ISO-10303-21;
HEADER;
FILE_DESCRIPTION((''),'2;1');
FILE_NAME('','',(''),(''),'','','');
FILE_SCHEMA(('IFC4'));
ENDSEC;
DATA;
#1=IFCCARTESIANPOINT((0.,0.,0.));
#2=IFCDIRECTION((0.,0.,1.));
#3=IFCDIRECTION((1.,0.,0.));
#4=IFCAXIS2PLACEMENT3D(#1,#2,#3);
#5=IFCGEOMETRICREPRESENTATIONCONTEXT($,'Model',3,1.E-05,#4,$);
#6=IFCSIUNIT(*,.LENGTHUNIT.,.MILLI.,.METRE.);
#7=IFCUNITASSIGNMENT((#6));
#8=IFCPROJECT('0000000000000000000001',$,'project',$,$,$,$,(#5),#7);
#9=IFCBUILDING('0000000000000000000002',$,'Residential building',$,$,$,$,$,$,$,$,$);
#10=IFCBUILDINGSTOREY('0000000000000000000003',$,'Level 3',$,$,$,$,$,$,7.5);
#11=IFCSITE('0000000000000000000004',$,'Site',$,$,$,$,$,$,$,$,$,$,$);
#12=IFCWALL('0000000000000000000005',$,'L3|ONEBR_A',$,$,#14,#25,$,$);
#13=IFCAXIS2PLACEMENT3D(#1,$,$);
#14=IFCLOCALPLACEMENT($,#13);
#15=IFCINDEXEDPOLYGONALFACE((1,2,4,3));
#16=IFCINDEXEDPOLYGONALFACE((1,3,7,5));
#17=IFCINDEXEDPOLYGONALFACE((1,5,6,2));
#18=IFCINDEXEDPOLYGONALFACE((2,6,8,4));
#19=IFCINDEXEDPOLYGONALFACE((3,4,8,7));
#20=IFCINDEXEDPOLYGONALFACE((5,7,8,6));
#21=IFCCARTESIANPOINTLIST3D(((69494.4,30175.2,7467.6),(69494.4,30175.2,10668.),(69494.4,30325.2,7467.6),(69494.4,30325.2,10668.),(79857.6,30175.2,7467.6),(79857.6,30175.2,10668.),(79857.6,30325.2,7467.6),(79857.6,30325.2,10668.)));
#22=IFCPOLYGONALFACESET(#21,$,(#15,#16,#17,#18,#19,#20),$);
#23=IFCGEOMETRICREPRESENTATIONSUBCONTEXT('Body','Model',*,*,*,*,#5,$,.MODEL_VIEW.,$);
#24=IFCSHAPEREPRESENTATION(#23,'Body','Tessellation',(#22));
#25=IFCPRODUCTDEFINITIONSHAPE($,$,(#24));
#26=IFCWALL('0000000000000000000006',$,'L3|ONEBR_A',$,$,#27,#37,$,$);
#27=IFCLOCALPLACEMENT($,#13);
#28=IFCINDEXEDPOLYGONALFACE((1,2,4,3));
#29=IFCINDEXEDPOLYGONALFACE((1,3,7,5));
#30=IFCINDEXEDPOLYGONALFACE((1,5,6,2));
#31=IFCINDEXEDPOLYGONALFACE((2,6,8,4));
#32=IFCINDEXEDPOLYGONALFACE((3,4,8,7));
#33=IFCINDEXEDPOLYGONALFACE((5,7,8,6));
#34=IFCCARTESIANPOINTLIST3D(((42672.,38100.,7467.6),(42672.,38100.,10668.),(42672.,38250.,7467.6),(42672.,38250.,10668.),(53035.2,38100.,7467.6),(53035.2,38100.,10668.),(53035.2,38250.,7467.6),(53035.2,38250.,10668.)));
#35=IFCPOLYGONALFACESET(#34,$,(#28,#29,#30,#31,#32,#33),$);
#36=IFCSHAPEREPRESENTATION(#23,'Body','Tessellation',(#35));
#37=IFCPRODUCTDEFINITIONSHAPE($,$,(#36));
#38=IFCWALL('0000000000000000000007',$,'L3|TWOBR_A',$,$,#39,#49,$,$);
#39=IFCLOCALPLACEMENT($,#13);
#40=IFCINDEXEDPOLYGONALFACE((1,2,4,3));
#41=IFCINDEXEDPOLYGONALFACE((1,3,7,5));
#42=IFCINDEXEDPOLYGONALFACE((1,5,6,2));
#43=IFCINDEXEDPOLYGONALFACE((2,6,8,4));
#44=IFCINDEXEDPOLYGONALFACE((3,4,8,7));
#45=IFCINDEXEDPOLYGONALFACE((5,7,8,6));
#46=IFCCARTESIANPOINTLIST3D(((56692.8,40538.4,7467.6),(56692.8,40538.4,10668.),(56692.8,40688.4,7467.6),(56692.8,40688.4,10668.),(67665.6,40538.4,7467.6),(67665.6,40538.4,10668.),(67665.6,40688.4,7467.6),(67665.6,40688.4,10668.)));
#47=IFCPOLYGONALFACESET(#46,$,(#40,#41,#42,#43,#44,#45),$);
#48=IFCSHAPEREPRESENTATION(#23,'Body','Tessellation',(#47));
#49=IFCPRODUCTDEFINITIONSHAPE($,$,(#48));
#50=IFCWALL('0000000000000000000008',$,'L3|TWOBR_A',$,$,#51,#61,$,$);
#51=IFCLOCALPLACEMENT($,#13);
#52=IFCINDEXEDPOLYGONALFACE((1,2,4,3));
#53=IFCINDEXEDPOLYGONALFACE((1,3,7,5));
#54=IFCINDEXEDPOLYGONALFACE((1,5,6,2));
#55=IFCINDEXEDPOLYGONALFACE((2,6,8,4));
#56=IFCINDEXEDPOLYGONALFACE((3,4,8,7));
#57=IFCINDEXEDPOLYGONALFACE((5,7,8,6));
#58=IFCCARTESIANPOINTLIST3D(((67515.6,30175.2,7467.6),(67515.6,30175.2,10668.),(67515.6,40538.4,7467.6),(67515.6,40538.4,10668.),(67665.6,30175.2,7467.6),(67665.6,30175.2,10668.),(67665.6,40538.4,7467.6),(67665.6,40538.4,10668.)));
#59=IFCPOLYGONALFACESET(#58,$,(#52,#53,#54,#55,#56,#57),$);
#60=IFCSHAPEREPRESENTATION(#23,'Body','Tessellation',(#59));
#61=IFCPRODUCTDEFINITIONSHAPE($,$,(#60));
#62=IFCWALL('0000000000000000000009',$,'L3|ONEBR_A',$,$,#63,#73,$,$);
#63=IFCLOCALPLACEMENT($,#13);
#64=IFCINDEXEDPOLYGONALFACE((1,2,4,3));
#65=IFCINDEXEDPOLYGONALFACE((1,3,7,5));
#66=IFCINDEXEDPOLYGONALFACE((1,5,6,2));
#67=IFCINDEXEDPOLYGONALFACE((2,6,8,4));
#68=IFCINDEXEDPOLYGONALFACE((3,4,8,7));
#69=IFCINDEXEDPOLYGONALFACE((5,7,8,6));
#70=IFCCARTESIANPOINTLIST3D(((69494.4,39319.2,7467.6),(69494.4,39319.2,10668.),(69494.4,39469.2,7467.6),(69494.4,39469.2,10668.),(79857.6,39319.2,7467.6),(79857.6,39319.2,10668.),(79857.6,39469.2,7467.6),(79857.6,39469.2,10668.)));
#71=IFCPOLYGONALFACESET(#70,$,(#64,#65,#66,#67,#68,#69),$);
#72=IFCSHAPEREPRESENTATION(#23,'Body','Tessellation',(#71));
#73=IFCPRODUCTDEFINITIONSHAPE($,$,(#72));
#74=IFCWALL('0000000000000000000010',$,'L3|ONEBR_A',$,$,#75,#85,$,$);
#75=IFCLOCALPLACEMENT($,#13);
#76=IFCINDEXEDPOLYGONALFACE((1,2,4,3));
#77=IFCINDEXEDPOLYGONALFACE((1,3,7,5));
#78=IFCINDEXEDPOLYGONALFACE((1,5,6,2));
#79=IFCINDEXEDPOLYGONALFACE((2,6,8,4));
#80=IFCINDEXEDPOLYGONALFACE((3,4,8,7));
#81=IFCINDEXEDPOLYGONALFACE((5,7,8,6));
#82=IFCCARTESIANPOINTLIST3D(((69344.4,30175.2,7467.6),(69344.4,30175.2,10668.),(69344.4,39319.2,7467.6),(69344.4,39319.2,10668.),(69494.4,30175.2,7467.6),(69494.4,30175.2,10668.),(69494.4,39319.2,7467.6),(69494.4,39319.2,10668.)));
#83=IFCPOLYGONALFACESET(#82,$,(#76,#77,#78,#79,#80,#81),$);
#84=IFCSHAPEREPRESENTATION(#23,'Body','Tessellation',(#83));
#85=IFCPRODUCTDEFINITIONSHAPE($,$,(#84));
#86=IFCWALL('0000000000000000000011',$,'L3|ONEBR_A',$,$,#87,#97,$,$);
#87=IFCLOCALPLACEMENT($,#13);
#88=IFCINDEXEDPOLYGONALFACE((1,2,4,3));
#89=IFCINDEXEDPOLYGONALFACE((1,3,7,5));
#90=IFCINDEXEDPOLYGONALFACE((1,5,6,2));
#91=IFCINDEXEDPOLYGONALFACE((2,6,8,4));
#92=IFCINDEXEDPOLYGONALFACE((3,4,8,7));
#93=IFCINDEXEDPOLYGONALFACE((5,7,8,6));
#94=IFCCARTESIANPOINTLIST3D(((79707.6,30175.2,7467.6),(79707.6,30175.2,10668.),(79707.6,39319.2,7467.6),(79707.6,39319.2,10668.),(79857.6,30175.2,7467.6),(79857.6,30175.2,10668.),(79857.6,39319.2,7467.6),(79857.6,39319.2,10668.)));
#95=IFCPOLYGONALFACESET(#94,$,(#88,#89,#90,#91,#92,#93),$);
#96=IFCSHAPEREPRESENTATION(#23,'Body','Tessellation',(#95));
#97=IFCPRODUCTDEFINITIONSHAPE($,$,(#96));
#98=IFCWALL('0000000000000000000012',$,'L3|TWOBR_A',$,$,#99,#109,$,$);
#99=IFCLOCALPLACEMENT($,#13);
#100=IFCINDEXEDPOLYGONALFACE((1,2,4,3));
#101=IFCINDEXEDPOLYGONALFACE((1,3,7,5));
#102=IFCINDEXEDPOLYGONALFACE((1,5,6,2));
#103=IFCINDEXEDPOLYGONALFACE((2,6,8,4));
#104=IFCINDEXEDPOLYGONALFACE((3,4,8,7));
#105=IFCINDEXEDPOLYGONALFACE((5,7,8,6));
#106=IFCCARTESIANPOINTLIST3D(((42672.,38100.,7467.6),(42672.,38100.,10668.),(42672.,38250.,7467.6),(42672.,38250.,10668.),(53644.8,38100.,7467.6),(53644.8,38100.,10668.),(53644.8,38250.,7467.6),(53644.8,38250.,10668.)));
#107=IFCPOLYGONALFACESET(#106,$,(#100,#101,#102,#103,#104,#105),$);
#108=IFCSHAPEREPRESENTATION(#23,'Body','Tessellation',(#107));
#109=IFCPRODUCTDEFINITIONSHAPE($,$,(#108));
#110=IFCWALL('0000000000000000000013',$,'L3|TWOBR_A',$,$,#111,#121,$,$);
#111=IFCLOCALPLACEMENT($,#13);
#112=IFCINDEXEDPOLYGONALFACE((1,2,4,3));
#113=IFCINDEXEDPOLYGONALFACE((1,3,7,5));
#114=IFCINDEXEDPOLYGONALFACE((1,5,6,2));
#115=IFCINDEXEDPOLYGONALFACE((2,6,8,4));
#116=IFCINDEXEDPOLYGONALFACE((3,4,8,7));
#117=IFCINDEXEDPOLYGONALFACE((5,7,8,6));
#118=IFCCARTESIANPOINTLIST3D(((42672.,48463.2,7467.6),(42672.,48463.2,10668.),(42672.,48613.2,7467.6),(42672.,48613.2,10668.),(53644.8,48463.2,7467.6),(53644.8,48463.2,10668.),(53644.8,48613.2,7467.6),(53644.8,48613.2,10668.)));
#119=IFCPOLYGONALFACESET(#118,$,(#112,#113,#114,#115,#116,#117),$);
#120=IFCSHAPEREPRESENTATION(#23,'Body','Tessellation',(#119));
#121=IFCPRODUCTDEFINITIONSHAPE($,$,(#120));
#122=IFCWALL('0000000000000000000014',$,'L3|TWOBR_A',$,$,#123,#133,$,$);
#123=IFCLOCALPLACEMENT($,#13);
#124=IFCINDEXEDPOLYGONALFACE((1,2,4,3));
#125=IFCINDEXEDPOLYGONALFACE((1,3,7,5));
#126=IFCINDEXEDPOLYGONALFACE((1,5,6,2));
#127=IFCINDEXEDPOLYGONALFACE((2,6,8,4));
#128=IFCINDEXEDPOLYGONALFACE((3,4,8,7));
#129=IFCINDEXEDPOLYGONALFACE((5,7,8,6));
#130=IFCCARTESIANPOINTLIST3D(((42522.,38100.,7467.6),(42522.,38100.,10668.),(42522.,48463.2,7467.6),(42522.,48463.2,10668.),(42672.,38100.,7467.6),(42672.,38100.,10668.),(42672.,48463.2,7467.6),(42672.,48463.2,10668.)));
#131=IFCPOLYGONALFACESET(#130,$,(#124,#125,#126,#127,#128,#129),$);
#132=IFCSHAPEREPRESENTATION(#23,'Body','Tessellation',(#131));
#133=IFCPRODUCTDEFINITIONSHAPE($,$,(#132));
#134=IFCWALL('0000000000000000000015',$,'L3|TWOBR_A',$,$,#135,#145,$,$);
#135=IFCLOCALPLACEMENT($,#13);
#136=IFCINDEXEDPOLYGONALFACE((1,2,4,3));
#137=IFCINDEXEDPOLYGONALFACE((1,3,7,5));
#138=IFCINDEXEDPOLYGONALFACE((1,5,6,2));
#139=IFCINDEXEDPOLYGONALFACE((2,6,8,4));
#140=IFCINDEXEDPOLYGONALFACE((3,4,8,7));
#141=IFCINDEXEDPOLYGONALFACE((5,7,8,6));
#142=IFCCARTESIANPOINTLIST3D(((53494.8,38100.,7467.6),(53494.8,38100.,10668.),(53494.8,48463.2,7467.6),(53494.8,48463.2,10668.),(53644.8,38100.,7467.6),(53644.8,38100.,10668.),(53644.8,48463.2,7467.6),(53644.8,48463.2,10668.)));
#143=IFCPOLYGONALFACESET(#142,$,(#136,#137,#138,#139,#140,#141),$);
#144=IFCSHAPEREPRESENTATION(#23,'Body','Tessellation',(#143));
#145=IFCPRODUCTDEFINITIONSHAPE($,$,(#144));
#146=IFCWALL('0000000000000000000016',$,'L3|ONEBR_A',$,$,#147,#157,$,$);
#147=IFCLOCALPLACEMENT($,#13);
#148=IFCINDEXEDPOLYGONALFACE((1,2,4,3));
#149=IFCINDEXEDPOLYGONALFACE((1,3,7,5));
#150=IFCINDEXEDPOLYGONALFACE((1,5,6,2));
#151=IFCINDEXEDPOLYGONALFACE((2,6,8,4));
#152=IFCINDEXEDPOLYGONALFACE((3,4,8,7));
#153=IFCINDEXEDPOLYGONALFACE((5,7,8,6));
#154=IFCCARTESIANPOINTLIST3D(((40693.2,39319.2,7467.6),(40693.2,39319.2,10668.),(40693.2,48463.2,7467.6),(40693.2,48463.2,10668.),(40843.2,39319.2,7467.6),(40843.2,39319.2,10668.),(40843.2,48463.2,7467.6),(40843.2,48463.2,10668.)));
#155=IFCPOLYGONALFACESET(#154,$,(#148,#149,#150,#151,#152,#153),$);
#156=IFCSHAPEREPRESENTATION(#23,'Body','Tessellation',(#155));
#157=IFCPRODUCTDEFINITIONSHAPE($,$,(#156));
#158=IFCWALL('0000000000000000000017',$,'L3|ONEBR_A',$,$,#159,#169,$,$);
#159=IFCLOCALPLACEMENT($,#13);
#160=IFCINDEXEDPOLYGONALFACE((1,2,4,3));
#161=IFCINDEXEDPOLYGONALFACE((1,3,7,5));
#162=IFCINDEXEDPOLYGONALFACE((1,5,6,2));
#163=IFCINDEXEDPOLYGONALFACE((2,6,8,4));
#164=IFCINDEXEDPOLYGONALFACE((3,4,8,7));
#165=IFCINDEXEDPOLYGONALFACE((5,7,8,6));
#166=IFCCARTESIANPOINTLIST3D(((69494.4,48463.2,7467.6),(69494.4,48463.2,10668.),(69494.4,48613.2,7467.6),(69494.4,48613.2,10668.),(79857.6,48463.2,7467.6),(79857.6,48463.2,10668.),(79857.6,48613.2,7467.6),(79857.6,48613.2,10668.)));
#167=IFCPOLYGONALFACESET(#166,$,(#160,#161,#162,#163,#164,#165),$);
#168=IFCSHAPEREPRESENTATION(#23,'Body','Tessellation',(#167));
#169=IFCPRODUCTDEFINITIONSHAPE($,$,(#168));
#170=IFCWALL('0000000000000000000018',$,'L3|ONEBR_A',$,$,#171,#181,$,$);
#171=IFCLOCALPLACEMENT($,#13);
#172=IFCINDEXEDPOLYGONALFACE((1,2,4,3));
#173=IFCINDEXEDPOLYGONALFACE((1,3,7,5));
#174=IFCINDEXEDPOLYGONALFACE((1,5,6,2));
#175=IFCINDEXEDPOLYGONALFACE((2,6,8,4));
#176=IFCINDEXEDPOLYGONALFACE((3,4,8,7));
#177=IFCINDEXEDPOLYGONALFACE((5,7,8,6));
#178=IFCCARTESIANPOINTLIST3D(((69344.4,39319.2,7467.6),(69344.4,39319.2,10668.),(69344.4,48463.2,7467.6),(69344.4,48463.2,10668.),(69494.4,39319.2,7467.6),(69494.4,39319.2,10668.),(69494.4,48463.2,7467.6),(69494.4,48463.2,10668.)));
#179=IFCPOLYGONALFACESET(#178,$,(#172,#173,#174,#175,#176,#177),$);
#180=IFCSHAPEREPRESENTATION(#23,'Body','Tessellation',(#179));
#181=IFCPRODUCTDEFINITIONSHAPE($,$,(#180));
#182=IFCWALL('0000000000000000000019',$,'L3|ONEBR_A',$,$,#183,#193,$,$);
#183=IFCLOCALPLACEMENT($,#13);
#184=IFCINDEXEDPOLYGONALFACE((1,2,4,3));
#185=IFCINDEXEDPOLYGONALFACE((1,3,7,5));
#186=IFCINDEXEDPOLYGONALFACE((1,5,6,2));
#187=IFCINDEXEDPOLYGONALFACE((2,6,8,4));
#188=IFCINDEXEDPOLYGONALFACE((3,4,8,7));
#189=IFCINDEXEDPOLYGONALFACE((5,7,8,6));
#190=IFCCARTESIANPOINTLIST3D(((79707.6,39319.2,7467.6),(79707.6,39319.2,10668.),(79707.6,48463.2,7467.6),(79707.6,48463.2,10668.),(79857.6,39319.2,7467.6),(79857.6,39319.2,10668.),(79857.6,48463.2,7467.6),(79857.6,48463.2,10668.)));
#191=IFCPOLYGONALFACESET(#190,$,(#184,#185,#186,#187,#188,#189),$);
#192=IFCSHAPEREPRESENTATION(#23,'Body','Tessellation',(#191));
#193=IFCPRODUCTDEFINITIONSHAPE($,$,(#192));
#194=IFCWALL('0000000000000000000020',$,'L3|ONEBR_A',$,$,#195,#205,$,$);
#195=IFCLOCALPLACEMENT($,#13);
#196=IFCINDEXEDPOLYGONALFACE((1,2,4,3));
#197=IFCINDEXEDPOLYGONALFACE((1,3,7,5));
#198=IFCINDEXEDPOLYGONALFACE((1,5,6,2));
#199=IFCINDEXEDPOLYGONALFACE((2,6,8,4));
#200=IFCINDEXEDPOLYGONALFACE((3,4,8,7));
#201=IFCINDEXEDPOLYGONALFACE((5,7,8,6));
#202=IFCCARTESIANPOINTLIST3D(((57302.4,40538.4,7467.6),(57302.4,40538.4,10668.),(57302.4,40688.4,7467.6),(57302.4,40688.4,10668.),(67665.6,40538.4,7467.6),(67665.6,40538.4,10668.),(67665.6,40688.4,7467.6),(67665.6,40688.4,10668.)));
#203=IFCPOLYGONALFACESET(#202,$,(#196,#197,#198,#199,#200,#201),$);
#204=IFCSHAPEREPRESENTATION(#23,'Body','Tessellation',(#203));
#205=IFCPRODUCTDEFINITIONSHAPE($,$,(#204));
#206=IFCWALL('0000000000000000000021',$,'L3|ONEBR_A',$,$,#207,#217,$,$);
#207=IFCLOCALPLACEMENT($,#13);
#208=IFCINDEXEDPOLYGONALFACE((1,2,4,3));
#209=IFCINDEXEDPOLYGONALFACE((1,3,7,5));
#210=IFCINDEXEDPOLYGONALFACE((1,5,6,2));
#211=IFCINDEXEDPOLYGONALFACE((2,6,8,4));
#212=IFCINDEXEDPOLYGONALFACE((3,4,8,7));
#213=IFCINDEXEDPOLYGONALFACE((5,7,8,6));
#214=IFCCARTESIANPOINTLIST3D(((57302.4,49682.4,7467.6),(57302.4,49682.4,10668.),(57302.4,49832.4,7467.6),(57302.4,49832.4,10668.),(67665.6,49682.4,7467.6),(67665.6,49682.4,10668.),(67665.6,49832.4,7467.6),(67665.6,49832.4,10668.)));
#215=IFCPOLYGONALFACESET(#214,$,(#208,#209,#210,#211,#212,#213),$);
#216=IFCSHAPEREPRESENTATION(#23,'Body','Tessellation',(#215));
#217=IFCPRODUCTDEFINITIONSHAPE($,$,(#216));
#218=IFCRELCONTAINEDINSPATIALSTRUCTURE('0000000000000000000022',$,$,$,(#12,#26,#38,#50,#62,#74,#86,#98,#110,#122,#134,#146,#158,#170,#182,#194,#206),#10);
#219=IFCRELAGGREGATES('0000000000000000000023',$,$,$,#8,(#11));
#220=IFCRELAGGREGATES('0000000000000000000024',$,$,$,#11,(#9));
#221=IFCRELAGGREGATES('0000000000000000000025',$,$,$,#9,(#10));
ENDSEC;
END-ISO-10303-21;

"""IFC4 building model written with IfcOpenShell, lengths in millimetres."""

from ifc_helpers import new_model, si_unit, frame, origin_with_axes, place, context, subcontext, project, spatial, indexed_curve, outline, extrude, element, save


model = new_model("IFC4")

# Units and contexts
model_context = context("Model", 3, precision=1e-05, world=origin_with_axes())
body_context = subcontext(model_context, "Body", "Model", "MODEL_VIEW")
ifc_project = project(units=[si_unit("LENGTHUNIT", "METRE", prefix="MILLI")], contexts=[model_context])

# Site, building, storey
site = spatial("IfcSite", under=ifc_project, Name="Site")
building = spatial("IfcBuilding", under=site, Name="Residential building")
storey = spatial("IfcBuildingStorey", under=building, Name="Level 3", Elevation=7.5)

# Walls
for number, where, z_axis, x_axis, name in (
    (1, (69494.4, 30175.2, 7467.6), (0.0, 0.0, 1.0), (1.0, 0.0, 0.0), "L3|ONEBR_A"),
    (2, (42672.0, 38100.0, 7467.6), (0.0, 0.0, 1.0), (1.0, 0.0, 0.0), "L3|ONEBR_A"),
):
    element("IfcWall", number, at=place(None, frame(where, z_axis=z_axis, x_axis=x_axis)), inside=storey, Name=name, context=body_context, shape_type="SweptSolid", body=[
        extrude(outline(indexed_curve([(0.0, 0.0), (0.0, 150.0), (10363.2, 150.0), (10363.2, 0.0), (0.0, 0.0)], self_intersect=False)), origin_with_axes(), (0.0, 0.0, 1.0), 3200.4),
    ])
wall_1_placement = place(None, frame((56692.8, 40538.4, 7467.6), z_axis=(0.0, 0.0, 1.0), x_axis=(1.0, 0.0, 0.0)))
element("IfcWall", 3, at=wall_1_placement, inside=storey, Name="L3|TWOBR_A", context=body_context, shape_type="SweptSolid", body=[
    extrude(outline(indexed_curve([(0.0, 0.0), (0.0, 150.0), (10972.8, 150.0), (10972.8, 0.0), (0.0, 0.0)], self_intersect=False)), origin_with_axes(), (0.0, 0.0, 1.0), 3200.4),
])
for number, where, z_axis, x_axis, name in (
    (4, (67665.6, 30175.2, 7467.6), (0.0, 0.0, 1.0), (0.0, 1.0, 0.0), "L3|TWOBR_A"),
    (5, (69494.4, 39319.2, 7467.6), (0.0, 0.0, 1.0), (1.0, 0.0, 0.0), "L3|ONEBR_A"),
):
    element("IfcWall", number, at=place(None, frame(where, z_axis=z_axis, x_axis=x_axis)), inside=storey, Name=name, context=body_context, shape_type="SweptSolid", body=[
        extrude(outline(indexed_curve([(0.0, 0.0), (0.0, 150.0), (10363.2, 150.0), (10363.2, 0.0), (0.0, 0.0)], self_intersect=False)), origin_with_axes(), (0.0, 0.0, 1.0), 3200.4),
    ])
for number, where, z_axis, x_axis, name in (
    (6, (69494.4, 30175.2, 7467.6), (0.0, 0.0, 1.0), (0.0, 1.0, 0.0), "L3|ONEBR_A"),
    (7, (79857.6, 30175.2, 7467.6), (0.0, 0.0, 1.0), (0.0, 1.0, 0.0), "L3|ONEBR_A"),
):
    element("IfcWall", number, at=place(None, frame(where, z_axis=z_axis, x_axis=x_axis)), inside=storey, Name=name, context=body_context, shape_type="SweptSolid", body=[
        extrude(outline(indexed_curve([(0.0, 0.0), (0.0, 150.0), (9144.0, 150.0), (9144.0, 0.0), (0.0, 0.0)], self_intersect=False)), origin_with_axes(), (0.0, 0.0, 1.0), 3200.4),
    ])
for number, where, z_axis, x_axis, name in (
    (8, (42672.0, 38100.0, 7467.6), (0.0, 0.0, 1.0), (1.0, 0.0, 0.0), "L3|TWOBR_A"),
    (9, (42672.0, 48463.2, 7467.6), (0.0, 0.0, 1.0), (1.0, 0.0, 0.0), "L3|TWOBR_A"),
):
    element("IfcWall", number, at=place(None, frame(where, z_axis=z_axis, x_axis=x_axis)), inside=storey, Name=name, context=body_context, shape_type="SweptSolid", body=[
        extrude(outline(indexed_curve([(0.0, 0.0), (0.0, 150.0), (10972.8, 150.0), (10972.8, 0.0), (0.0, 0.0)], self_intersect=False)), origin_with_axes(), (0.0, 0.0, 1.0), 3200.4),
    ])
for number, where, z_axis, x_axis, name in (
    (10, (42672.0, 38100.0, 7467.6), (0.0, 0.0, 1.0), (0.0, 1.0, 0.0), "L3|TWOBR_A"),
    (11, (53644.8, 38100.0, 7467.6), (0.0, 0.0, 1.0), (0.0, 1.0, 0.0), "L3|TWOBR_A"),
):
    element("IfcWall", number, at=place(None, frame(where, z_axis=z_axis, x_axis=x_axis)), inside=storey, Name=name, context=body_context, shape_type="SweptSolid", body=[
        extrude(outline(indexed_curve([(0.0, 0.0), (0.0, 150.0), (10363.2, 150.0), (10363.2, 0.0), (0.0, 0.0)], self_intersect=False)), origin_with_axes(), (0.0, 0.0, 1.0), 3200.4),
    ])
wall_2_placement = place(None, frame((40843.2, 39319.2, 7467.6), z_axis=(0.0, 0.0, 1.0), x_axis=(0.0, 1.0, 0.0)))
element("IfcWall", 12, at=wall_2_placement, inside=storey, Name="L3|ONEBR_A", context=body_context, shape_type="SweptSolid", body=[
    extrude(outline(indexed_curve([(0.0, 0.0), (0.0, 150.0), (9144.0, 150.0), (9144.0, 0.0), (0.0, 0.0)], self_intersect=False)), origin_with_axes(), (0.0, 0.0, 1.0), 3200.4),
])
for number, where, z_axis, x_axis, name in (
    (13, (69494.4, 48463.2, 7467.6), (0.0, 0.0, 1.0), (1.0, 0.0, 0.0), "L3|ONEBR_A"),
):
    element("IfcWall", number, at=place(None, frame(where, z_axis=z_axis, x_axis=x_axis)), inside=storey, Name=name, context=body_context, shape_type="SweptSolid", body=[
        extrude(outline(indexed_curve([(0.0, 0.0), (0.0, 150.0), (10363.2, 150.0), (10363.2, 0.0), (0.0, 0.0)], self_intersect=False)), origin_with_axes(), (0.0, 0.0, 1.0), 3200.4),
    ])
for number, where, z_axis, x_axis, name in (
    (14, (69494.4, 39319.2, 7467.6), (0.0, 0.0, 1.0), (0.0, 1.0, 0.0), "L3|ONEBR_A"),
    (15, (79857.6, 39319.2, 7467.6), (0.0, 0.0, 1.0), (0.0, 1.0, 0.0), "L3|ONEBR_A"),
):
    element("IfcWall", number, at=place(None, frame(where, z_axis=z_axis, x_axis=x_axis)), inside=storey, Name=name, context=body_context, shape_type="SweptSolid", body=[
        extrude(outline(indexed_curve([(0.0, 0.0), (0.0, 150.0), (9144.0, 150.0), (9144.0, 0.0), (0.0, 0.0)], self_intersect=False)), origin_with_axes(), (0.0, 0.0, 1.0), 3200.4),
    ])
for number, where, z_axis, x_axis, name in (
    (16, (57302.4, 40538.4, 7467.6), (0.0, 0.0, 1.0), (1.0, 0.0, 0.0), "L3|ONEBR_A"),
    (17, (57302.4, 49682.4, 7467.6), (0.0, 0.0, 1.0), (1.0, 0.0, 0.0), "L3|ONEBR_A"),
):
    element("IfcWall", number, at=place(None, frame(where, z_axis=z_axis, x_axis=x_axis)), inside=storey, Name=name, context=body_context, shape_type="SweptSolid", body=[
        extrude(outline(indexed_curve([(0.0, 0.0), (0.0, 150.0), (10363.2, 150.0), (10363.2, 0.0), (0.0, 0.0)], self_intersect=False)), origin_with_axes(), (0.0, 0.0, 1.0), 3200.4),
    ])

save(model, "model.ifc")
